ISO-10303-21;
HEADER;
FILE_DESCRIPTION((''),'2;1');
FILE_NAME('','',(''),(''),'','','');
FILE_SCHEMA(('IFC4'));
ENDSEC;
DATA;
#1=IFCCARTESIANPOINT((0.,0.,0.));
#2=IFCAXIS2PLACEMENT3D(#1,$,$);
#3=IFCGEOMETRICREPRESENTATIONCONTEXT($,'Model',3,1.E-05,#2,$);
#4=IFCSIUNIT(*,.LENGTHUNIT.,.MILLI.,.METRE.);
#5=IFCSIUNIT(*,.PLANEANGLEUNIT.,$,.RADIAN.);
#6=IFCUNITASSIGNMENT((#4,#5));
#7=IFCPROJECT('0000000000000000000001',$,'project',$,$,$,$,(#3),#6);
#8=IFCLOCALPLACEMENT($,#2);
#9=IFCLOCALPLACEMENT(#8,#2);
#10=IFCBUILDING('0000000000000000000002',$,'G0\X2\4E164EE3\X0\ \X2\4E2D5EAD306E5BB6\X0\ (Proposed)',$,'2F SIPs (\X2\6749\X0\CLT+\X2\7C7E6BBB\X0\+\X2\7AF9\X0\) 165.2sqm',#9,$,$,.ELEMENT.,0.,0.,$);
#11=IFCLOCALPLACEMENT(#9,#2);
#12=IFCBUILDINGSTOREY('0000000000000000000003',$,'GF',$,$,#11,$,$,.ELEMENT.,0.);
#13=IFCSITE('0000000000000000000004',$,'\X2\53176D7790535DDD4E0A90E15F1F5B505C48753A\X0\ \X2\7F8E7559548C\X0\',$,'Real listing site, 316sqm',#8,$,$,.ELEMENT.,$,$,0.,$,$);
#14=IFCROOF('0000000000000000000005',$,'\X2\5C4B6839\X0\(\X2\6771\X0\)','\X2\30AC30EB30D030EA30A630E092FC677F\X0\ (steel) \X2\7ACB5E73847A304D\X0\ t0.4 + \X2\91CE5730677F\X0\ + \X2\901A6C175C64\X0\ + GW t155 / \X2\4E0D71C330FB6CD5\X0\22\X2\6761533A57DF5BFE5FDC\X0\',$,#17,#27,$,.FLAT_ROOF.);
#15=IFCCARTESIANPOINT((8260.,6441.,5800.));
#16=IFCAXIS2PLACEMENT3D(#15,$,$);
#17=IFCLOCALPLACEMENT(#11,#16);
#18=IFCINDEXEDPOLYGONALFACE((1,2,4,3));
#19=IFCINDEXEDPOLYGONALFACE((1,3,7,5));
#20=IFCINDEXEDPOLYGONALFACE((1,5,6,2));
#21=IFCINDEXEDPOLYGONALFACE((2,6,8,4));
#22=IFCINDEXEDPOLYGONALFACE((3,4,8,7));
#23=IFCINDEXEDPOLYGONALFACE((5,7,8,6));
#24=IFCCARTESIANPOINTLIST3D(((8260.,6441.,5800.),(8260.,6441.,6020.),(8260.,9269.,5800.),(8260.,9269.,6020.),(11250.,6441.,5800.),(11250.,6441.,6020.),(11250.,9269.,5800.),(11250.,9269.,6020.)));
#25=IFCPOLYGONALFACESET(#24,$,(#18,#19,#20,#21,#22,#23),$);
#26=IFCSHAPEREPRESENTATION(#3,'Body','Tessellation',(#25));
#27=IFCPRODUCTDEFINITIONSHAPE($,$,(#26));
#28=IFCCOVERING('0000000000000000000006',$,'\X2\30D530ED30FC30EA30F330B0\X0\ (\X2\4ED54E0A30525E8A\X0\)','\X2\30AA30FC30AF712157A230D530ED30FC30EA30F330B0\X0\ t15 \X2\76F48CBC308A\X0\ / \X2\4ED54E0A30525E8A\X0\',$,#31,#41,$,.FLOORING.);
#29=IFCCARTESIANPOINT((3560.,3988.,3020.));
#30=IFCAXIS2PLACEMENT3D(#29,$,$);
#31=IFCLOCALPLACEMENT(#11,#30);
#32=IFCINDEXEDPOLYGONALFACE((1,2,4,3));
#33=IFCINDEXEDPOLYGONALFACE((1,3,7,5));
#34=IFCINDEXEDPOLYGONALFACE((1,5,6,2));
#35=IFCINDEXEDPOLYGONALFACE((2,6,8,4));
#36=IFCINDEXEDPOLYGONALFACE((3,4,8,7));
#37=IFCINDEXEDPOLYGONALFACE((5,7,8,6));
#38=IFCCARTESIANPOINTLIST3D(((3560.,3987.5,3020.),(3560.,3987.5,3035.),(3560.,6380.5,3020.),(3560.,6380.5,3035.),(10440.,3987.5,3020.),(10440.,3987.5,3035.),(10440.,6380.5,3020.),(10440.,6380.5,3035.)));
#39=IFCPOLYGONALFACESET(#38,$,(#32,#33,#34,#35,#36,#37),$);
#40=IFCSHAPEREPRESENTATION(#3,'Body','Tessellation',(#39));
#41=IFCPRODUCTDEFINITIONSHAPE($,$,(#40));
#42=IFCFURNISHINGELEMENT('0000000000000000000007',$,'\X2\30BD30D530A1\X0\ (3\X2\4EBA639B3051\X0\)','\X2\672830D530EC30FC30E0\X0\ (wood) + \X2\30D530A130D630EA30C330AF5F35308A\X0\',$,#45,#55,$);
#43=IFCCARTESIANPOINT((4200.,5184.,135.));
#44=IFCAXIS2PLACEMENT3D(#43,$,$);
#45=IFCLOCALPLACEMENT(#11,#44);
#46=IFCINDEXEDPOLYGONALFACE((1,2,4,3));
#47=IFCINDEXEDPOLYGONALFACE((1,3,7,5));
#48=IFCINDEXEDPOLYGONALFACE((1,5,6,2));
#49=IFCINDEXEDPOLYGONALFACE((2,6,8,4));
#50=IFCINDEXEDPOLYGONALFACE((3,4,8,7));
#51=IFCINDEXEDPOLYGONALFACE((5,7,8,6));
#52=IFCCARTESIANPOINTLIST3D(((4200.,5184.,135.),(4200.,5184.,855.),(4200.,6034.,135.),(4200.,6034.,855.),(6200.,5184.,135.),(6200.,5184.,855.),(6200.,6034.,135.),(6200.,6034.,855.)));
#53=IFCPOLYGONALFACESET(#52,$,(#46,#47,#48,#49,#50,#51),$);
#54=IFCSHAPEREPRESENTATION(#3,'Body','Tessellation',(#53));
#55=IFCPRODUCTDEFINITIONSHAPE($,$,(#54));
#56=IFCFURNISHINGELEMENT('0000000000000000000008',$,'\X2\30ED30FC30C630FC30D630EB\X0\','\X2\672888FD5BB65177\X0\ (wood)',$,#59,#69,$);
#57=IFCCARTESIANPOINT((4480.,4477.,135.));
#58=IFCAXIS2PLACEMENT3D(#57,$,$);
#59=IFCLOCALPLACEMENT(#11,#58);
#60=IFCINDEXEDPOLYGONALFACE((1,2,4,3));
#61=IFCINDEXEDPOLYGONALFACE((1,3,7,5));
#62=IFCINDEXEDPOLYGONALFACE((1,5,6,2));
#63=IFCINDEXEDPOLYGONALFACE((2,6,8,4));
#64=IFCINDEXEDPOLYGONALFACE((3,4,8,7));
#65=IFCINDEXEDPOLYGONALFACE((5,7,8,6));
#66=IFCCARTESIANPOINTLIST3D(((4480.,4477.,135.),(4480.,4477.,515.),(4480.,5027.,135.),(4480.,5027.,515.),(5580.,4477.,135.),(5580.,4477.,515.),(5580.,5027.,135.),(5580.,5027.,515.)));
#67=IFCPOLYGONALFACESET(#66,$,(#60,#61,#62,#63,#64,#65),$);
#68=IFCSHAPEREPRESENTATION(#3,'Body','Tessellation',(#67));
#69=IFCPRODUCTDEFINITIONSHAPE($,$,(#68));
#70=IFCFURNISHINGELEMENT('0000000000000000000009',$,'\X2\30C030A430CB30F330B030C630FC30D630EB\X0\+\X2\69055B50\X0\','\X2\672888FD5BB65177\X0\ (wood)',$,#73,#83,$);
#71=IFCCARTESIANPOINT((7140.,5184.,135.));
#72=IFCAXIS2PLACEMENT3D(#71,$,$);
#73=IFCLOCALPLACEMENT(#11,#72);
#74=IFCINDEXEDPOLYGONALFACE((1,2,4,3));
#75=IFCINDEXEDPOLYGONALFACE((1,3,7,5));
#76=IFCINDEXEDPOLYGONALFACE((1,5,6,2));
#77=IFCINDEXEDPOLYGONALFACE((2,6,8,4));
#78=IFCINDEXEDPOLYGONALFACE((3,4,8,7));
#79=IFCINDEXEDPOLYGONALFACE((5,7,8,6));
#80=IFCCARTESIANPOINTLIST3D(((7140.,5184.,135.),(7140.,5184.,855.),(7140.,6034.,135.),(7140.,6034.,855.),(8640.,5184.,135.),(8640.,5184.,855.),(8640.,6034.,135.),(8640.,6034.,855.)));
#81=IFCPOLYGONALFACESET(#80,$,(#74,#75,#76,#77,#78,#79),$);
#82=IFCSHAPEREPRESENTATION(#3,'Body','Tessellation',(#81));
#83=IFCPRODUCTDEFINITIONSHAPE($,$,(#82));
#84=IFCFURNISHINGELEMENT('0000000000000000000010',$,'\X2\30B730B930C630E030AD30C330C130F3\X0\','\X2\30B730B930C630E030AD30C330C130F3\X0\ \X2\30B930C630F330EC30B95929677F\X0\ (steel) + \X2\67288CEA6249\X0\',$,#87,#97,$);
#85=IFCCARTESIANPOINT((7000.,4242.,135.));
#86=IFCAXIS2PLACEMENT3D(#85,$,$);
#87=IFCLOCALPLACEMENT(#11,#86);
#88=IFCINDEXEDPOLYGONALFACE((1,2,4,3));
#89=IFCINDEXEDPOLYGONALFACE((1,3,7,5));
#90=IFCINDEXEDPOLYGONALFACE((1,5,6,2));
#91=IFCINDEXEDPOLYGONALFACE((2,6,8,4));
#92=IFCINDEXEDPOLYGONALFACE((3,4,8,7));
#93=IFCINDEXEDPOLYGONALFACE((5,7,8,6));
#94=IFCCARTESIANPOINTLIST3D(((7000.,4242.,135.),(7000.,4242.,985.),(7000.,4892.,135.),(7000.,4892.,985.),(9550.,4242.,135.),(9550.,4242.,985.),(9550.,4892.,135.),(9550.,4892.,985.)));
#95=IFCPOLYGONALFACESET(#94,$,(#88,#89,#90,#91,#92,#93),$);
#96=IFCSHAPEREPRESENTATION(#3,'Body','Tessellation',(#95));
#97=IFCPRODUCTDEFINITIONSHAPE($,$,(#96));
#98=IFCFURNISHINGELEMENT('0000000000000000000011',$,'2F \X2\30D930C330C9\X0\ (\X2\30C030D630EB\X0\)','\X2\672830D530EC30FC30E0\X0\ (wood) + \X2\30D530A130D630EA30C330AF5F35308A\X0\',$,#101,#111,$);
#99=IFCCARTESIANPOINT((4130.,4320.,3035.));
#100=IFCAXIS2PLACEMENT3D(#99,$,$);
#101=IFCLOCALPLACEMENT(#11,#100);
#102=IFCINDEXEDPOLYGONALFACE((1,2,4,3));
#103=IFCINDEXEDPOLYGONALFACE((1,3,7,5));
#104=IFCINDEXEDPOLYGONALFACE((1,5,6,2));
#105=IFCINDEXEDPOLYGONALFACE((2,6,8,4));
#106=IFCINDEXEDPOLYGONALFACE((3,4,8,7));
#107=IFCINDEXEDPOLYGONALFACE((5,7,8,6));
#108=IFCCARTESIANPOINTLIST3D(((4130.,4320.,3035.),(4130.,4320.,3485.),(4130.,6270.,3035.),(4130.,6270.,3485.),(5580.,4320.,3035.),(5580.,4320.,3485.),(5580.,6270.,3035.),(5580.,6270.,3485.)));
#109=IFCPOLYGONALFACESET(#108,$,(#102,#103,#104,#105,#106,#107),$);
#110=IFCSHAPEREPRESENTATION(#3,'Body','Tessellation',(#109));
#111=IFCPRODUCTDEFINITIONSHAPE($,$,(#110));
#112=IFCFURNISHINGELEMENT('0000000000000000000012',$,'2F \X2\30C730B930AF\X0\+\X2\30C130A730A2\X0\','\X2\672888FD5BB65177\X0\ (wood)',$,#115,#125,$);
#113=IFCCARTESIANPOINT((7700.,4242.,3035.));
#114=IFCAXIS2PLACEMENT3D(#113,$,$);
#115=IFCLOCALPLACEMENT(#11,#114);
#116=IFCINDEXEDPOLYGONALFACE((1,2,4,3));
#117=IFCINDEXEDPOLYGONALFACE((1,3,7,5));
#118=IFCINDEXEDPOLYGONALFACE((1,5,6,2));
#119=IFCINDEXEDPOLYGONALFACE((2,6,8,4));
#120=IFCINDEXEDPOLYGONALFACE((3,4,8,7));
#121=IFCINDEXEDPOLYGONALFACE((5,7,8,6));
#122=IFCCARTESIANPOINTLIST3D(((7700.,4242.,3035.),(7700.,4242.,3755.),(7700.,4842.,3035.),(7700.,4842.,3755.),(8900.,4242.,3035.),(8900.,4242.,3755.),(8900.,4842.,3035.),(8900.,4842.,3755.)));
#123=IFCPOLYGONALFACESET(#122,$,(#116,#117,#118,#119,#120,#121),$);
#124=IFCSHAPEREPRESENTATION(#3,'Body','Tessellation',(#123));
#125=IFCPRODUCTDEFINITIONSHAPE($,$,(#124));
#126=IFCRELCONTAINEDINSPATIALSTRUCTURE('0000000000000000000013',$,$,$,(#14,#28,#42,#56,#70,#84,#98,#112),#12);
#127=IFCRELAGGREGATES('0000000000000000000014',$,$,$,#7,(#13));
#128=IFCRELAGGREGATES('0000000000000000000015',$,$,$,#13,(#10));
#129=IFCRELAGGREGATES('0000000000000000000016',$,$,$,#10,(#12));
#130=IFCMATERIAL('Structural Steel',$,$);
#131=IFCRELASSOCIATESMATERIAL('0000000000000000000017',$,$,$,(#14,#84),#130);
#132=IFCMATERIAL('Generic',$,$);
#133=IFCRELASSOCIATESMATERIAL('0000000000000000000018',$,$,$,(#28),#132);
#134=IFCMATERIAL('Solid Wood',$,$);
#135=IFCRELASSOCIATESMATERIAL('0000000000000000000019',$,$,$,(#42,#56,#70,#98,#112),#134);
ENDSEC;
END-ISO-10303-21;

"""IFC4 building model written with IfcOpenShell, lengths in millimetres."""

from ifc_helpers import new_model, si_unit, frame, frame_2d, origin, place, context, project, spatial, rectangle, extrude, material, element, save


model = new_model("IFC4")

# Units and contexts
model_context = context("Model", 3, precision=1e-05, world=origin())
ifc_project = project(units=[si_unit("LENGTHUNIT", "METRE", prefix="MILLI"), si_unit("PLANEANGLEUNIT", "RADIAN")], contexts=[model_context])

# Site, building, storey
site_placement = place(None, origin())
site = spatial("IfcSite", under=ifc_project, at=site_placement, Name="北海道川上郡弟子屈町 美留和", ObjectType="Real listing site, 316sqm", CompositionType="ELEMENT", RefElevation=0.0)
building_placement = place(site_placement, origin())
building = spatial("IfcBuilding", under=site, at=building_placement, Name="G0世代 中庭の家 (Proposed)", ObjectType="2F SIPs (杉CLT+籾殻+竹) 165.2sqm", CompositionType="ELEMENT", ElevationOfRefHeight=0.0, ElevationOfTerrain=0.0)
storey_placement = place(building_placement, origin())
storey = spatial("IfcBuildingStorey", under=building, at=storey_placement, Name="GF", CompositionType="ELEMENT", Elevation=0.0)

# Shared definitions
ifc_material_1 = material(Name="Solid Wood")

# Shared definitions
ifc_material_2 = material(Name="Generic")

# Roof
ifc_material_3 = material(Name="Structural Steel")
roof_placement = place(storey_placement, frame((8260.0, 6441.0, 5800.0)))
element("IfcRoof", 1, at=roof_placement, inside=storey, material=ifc_material_3, Name="屋根(東)", Description="ガルバリウム鋼板 (steel) 立平葺き t0.4 + 野地板 + 通気層 + GW t155 / 不燃・法22条区域対応", PredefinedType="FLAT_ROOF", context=model_context, shape_type="SweptSolid", body=[
    extrude(rectangle(XDim=2990.0, YDim=2828.0, at=frame_2d((1495.0, 1414.0))), frame((8260.0, 6441.0, 5800.0)), (0.0, 0.0, 1.0), 220.0),
])

# Covering
covering_placement = place(storey_placement, frame((3560.0, 3988.0, 3020.0)))
element("IfcCovering", 2, at=covering_placement, inside=storey, material=ifc_material_2, Name="フローリング (仕上げ床)", Description="オーク無垢フローリング t15 直貼り / 仕上げ床", PredefinedType="FLOORING", context=model_context, shape_type="SweptSolid", body=[
    extrude(rectangle(XDim=6880.0, YDim=2393.0, at=frame_2d((3440.0, 1196.0))), frame((3560.0, 3988.0, 3020.0)), (0.0, 0.0, 1.0), 15.0),
])

# Furnishing elements
furnishing_1_placement = place(storey_placement, frame((4200.0, 5184.0, 135.0)))
element("IfcFurnishingElement", 3, at=furnishing_1_placement, inside=storey, material=ifc_material_1, Name="ソファ (3人掛け)", Description="木フレーム (wood) + ファブリック張り", context=model_context, shape_type="SweptSolid", body=[
    extrude(rectangle(XDim=2000.0, YDim=850.0, at=frame_2d((1000.0, 425.0))), frame((4200.0, 5184.0, 135.0)), (0.0, 0.0, 1.0), 720.0),
])
furnishing_2_placement = place(storey_placement, frame((4480.0, 4477.0, 135.0)))
element("IfcFurnishingElement", 4, at=furnishing_2_placement, inside=storey, material=ifc_material_1, Name="ローテーブル", Description="木製家具 (wood)", context=model_context, shape_type="SweptSolid", body=[
    extrude(rectangle(XDim=1100.0, YDim=550.0, at=frame_2d((550.0, 275.0))), frame((4480.0, 4477.0, 135.0)), (0.0, 0.0, 1.0), 380.0),
])
furnishing_3_placement = place(storey_placement, frame((7140.0, 5184.0, 135.0)))
element("IfcFurnishingElement", 5, at=furnishing_3_placement, inside=storey, material=ifc_material_1, Name="ダイニングテーブル+椅子", Description="木製家具 (wood)", context=model_context, shape_type="SweptSolid", body=[
    extrude(rectangle(XDim=1500.0, YDim=850.0, at=frame_2d((750.0, 425.0))), frame((7140.0, 5184.0, 135.0)), (0.0, 0.0, 1.0), 720.0),
])
furnishing_4_placement = place(storey_placement, frame((7000.0, 4242.0, 135.0)))
element("IfcFurnishingElement", 6, at=furnishing_4_placement, inside=storey, material=ifc_material_3, Name="システムキッチン", Description="システムキッチン ステンレス天板 (steel) + 木質扉", context=model_context, shape_type="SweptSolid", body=[
    extrude(rectangle(XDim=2550.0, YDim=650.0, at=frame_2d((1275.0, 325.0))), frame((7000.0, 4242.0, 135.0)), (0.0, 0.0, 1.0), 850.0),
])
furnishing_5_placement = place(storey_placement, frame((4130.0, 4320.0, 3035.0)))
element("IfcFurnishingElement", 7, at=furnishing_5_placement, inside=storey, material=ifc_material_1, Name="2F ベッド (ダブル)", Description="木フレーム (wood) + ファブリック張り", context=model_context, shape_type="SweptSolid", body=[
    extrude(rectangle(XDim=1450.0, YDim=1950.0, at=frame_2d((725.0, 975.0))), frame((4130.0, 4320.0, 3035.0)), (0.0, 0.0, 1.0), 450.0),
])
furnishing_6_placement = place(storey_placement, frame((7700.0, 4242.0, 3035.0)))
element("IfcFurnishingElement", 8, at=furnishing_6_placement, inside=storey, material=ifc_material_1, Name="2F デスク+チェア", Description="木製家具 (wood)", context=model_context, shape_type="SweptSolid", body=[
    extrude(rectangle(XDim=1200.0, YDim=600.0, at=frame_2d((600.0, 300.0))), frame((7700.0, 4242.0, 3035.0)), (0.0, 0.0, 1.0), 720.0),
])

save(model, "model.ifc")
